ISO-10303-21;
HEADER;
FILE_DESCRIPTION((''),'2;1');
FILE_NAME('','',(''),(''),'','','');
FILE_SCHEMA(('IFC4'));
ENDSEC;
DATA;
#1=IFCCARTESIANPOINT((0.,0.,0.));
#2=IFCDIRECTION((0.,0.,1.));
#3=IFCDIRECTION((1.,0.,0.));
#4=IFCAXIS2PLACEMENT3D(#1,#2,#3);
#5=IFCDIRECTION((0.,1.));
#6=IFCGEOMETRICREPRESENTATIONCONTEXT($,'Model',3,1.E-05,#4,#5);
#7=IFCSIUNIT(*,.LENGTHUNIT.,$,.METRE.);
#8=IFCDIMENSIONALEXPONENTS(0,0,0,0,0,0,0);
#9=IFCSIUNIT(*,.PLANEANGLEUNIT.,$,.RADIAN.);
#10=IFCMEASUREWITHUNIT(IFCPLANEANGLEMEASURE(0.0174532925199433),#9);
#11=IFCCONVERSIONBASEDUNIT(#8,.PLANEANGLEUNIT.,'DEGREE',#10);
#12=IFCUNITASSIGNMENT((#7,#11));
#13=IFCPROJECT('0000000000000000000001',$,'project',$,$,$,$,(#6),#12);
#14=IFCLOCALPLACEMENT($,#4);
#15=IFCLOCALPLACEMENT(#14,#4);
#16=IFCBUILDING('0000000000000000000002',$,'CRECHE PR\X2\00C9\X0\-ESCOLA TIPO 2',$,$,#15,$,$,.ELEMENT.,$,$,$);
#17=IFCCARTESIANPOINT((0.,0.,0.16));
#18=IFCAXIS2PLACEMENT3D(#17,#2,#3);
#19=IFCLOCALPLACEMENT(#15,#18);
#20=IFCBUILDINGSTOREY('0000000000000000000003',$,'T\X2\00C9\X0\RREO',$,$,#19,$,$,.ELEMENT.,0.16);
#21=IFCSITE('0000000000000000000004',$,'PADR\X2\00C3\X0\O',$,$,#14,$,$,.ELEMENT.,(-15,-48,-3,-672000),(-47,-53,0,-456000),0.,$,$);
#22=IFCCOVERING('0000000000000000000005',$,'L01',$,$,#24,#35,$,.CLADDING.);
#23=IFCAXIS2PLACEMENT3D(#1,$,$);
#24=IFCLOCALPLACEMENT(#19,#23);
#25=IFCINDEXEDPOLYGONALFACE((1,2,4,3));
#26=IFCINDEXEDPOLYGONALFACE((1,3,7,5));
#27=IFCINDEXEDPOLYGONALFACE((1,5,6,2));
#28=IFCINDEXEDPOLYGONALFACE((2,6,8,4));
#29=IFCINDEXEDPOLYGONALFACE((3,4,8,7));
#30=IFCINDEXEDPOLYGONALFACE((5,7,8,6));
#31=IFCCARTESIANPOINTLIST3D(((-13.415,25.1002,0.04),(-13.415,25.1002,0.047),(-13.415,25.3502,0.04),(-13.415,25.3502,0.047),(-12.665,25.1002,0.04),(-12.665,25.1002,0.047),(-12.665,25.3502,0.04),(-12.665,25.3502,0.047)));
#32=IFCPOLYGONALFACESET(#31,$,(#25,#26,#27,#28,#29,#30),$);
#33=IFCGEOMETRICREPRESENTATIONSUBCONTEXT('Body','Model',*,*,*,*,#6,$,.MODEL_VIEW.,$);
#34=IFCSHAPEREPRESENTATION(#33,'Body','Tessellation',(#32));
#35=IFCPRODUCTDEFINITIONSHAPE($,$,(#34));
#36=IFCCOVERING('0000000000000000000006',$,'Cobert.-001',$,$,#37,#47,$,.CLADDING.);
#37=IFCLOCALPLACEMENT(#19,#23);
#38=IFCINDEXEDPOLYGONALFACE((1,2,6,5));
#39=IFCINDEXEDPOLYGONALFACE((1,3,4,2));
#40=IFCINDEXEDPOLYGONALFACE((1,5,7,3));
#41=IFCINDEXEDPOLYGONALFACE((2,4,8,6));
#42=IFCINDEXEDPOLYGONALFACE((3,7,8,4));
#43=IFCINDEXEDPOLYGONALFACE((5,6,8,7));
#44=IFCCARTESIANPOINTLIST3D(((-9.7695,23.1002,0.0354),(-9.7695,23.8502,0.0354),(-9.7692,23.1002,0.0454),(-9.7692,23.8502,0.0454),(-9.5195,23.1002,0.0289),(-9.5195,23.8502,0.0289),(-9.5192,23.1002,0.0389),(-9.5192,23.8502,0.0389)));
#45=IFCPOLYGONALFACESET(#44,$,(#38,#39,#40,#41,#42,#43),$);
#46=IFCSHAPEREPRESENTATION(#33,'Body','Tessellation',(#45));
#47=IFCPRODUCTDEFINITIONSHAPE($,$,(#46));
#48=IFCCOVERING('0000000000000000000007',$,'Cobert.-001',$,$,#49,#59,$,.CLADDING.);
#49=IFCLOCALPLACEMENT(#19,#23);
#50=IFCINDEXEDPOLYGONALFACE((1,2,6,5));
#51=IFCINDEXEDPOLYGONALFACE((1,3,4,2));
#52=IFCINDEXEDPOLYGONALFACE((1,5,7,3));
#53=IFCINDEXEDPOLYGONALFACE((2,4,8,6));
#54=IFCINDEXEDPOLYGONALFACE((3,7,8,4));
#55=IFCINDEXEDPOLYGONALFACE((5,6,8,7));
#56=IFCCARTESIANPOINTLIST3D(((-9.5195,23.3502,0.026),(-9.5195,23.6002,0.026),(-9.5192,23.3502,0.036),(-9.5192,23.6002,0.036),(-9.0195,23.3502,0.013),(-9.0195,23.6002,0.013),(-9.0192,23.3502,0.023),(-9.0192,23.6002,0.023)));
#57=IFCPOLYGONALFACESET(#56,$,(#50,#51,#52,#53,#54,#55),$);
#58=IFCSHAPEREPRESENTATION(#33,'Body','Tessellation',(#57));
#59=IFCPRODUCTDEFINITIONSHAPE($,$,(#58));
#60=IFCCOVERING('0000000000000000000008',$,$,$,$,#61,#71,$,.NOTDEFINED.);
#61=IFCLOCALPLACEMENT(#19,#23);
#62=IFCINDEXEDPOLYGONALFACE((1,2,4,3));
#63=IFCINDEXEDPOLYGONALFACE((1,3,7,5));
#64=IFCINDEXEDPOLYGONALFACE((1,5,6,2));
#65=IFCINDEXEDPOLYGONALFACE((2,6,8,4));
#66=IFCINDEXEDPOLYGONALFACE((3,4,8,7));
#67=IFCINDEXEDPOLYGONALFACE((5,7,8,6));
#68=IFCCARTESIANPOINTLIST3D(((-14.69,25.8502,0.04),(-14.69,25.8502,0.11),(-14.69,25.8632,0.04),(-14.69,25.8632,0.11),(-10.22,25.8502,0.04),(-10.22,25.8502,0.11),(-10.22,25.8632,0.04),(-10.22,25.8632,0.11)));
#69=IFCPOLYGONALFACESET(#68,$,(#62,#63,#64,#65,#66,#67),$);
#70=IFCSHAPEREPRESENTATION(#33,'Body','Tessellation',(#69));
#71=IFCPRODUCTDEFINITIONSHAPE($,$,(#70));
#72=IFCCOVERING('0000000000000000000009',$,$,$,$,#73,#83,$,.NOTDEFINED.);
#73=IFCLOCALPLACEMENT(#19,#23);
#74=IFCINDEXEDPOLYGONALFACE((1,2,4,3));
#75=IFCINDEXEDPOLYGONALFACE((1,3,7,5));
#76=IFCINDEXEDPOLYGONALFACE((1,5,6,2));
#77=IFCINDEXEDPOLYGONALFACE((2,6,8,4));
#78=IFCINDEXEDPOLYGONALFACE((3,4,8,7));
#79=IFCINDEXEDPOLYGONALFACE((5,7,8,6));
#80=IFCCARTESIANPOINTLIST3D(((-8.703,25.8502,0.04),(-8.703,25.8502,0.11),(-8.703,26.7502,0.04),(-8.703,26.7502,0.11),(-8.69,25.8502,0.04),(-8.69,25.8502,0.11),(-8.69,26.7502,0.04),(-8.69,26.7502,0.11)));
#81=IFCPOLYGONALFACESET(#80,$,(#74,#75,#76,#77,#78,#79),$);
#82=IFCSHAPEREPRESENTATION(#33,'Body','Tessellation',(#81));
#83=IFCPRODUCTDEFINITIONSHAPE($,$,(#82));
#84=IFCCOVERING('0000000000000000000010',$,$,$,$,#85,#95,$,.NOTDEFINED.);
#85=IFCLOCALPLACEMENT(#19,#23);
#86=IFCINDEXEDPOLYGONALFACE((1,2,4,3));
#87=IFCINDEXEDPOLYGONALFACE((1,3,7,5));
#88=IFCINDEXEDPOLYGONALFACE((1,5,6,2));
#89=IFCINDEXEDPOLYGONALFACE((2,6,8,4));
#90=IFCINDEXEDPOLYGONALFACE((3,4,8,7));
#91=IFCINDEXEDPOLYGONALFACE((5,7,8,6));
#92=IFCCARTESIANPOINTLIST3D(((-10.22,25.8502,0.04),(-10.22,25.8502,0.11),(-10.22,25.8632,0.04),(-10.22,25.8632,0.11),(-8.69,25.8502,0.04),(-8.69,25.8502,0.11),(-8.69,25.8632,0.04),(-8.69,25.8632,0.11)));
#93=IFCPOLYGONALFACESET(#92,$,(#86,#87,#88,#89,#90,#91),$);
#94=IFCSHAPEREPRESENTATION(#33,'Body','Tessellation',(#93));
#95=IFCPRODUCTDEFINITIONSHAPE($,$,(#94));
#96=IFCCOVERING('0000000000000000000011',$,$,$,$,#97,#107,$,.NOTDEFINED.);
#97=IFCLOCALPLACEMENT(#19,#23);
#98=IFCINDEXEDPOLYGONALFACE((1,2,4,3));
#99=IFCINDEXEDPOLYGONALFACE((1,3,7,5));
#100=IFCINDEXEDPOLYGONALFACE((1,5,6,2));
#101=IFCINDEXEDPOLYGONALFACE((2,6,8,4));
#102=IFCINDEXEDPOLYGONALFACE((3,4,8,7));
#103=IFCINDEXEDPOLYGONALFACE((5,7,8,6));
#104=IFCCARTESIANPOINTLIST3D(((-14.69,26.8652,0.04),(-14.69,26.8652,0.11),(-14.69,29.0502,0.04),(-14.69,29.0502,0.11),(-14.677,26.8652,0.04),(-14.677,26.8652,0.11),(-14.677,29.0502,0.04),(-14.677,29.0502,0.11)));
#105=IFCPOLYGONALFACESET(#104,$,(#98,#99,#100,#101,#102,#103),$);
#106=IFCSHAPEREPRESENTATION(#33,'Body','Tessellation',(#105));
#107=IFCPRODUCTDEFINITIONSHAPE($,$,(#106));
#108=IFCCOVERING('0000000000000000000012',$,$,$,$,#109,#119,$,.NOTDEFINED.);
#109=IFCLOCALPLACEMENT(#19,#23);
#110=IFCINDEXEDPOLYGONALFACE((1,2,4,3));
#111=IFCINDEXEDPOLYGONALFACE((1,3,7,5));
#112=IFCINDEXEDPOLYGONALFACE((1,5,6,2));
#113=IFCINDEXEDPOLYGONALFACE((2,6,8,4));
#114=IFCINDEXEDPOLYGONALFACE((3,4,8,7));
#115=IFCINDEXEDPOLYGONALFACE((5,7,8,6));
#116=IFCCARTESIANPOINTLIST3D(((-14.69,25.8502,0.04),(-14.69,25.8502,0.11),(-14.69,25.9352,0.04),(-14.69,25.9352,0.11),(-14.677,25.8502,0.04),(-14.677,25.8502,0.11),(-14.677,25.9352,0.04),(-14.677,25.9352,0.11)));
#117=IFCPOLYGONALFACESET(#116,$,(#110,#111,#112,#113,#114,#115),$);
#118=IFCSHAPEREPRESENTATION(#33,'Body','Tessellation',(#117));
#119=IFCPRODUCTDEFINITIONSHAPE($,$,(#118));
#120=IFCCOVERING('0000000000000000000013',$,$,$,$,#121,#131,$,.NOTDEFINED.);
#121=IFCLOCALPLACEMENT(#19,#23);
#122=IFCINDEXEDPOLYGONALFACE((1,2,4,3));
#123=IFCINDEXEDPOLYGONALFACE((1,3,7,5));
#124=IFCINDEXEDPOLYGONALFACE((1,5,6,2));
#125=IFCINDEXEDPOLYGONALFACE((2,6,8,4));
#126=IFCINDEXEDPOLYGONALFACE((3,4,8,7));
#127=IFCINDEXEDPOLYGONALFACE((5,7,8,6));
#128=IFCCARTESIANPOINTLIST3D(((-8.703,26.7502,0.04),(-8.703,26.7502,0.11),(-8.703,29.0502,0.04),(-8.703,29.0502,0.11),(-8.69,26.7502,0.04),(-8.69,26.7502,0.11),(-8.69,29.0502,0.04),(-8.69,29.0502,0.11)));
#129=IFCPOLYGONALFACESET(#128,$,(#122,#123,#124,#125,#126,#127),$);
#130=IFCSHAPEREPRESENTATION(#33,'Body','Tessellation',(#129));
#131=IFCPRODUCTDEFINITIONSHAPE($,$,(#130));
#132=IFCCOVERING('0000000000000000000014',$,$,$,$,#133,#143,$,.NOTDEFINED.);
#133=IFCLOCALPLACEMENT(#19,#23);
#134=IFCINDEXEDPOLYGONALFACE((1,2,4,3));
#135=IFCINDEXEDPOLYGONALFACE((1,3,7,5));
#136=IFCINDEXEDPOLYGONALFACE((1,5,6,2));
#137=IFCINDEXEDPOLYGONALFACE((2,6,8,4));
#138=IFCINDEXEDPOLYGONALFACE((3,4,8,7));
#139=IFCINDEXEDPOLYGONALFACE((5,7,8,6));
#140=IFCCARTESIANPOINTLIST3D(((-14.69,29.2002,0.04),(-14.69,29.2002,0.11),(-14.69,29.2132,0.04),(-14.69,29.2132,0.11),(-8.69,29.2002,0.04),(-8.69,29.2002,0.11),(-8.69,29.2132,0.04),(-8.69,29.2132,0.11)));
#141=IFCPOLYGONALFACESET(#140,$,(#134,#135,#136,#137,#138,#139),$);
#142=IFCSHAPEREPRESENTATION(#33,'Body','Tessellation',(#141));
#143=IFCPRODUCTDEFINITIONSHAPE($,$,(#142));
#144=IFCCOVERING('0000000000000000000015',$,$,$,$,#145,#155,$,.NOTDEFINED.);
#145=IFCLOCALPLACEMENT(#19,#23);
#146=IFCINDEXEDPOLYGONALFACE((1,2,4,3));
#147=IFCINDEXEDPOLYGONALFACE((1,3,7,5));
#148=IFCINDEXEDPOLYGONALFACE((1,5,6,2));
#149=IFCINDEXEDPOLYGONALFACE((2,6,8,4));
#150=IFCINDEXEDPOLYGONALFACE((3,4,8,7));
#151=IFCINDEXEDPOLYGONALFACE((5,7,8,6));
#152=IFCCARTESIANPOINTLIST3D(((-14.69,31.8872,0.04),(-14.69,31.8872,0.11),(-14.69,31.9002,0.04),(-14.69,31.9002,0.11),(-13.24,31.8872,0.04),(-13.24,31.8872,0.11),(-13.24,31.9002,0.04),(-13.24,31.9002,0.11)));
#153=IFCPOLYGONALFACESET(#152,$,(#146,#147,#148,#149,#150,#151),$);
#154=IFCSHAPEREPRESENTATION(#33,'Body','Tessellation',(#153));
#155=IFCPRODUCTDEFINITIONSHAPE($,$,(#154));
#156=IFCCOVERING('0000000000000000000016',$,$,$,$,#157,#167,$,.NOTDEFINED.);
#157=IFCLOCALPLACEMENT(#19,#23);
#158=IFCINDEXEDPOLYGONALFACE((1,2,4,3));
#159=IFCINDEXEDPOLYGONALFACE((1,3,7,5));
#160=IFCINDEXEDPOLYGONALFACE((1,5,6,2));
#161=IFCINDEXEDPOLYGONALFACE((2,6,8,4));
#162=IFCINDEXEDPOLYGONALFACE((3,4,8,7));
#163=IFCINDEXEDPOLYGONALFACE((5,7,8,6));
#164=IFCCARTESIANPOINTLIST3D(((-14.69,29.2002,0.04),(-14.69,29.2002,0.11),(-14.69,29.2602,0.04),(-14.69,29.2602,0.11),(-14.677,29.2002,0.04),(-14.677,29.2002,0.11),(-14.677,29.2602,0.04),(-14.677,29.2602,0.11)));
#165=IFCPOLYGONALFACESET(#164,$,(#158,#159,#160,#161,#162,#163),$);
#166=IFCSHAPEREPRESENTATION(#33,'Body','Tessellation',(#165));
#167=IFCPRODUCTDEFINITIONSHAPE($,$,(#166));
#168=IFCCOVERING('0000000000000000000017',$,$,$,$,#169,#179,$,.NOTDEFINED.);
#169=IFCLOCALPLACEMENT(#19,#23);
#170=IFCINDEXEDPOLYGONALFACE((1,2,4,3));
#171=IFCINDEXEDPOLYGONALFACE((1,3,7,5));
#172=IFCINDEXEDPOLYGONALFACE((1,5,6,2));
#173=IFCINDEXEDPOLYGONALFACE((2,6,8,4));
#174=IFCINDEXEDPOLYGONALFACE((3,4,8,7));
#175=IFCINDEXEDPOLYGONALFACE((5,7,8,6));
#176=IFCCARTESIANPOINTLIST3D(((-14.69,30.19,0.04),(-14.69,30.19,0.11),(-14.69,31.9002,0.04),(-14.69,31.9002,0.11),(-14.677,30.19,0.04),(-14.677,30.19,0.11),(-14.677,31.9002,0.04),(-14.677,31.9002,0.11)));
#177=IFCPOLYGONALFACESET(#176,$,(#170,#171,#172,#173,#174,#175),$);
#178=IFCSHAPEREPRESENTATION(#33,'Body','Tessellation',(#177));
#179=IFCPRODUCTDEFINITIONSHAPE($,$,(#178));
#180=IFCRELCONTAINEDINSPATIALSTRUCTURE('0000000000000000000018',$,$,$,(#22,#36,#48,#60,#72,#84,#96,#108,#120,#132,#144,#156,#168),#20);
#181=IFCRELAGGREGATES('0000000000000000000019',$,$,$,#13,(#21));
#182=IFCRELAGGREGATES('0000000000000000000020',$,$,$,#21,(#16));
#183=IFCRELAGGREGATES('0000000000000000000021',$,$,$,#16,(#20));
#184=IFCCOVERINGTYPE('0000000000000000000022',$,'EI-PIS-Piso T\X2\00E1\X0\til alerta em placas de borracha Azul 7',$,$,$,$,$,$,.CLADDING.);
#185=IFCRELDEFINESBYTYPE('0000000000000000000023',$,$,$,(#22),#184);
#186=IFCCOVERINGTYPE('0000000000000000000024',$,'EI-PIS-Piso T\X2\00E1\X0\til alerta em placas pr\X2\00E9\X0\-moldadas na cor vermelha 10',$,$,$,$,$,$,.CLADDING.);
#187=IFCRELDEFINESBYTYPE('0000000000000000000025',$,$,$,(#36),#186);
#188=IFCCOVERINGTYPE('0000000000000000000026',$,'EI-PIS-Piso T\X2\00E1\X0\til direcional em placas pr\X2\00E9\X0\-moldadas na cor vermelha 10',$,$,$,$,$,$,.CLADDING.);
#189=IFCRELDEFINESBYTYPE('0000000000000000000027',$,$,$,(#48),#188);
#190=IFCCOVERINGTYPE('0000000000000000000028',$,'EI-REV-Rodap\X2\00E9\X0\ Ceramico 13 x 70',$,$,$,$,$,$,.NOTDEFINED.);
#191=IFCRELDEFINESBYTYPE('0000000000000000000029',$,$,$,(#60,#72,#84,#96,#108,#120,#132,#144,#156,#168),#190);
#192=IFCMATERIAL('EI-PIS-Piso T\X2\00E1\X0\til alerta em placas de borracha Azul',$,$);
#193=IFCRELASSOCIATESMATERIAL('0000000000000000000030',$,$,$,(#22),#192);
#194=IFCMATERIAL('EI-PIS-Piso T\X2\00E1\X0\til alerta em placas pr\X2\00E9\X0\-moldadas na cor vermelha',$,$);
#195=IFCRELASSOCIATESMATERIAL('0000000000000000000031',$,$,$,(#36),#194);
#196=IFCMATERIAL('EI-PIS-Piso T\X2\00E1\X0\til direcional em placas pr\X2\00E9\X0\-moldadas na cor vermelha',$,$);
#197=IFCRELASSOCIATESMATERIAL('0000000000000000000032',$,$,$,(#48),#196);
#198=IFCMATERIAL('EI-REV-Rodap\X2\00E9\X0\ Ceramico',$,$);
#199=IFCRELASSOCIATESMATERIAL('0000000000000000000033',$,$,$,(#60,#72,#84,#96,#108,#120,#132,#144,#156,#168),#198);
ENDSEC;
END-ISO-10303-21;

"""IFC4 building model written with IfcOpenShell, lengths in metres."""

from ifc_helpers import new_model, entity, si_unit, converted_unit, direction, frame, frame_2d, origin_with_axes, place, context, subcontext, project, spatial, line, indexed_curve, rectangle, outline, extrude, material, type_object, element, save


model = new_model("IFC4")

# Units and contexts
model_context = context("Model", 3, precision=1e-05, world=origin_with_axes(), true_north=direction((0.0, 1.0)))
body_context = subcontext(model_context, "Body", "Model", "MODEL_VIEW")
ifc_project = project(units=[si_unit("LENGTHUNIT", "METRE"), converted_unit("PLANEANGLEUNIT", "DEGREE", entity("IfcPlaneAngleMeasure", 0.0174532925199433), si_unit("PLANEANGLEUNIT", "RADIAN"), dimensions=[0, 0, 0, 0, 0, 0, 0])], contexts=[model_context])

# Site, building, storey
site_placement = place(None, origin_with_axes())
site = spatial("IfcSite", under=ifc_project, at=site_placement, Name="PADRÃO", CompositionType="ELEMENT", RefLatitude=(-15, -48, -3, -672000), RefLongitude=(-47, -53, 0, -456000), RefElevation=0.0)
building_placement = place(site_placement, origin_with_axes())
building = spatial("IfcBuilding", under=site, at=building_placement, Name="CRECHE PRÉ-ESCOLA TIPO 2", CompositionType="ELEMENT")
storey_placement = place(building_placement, frame((0.0, 0.0, 0.16), z_axis=(0.0, 0.0, 1.0), x_axis=(1.0, 0.0, 0.0)))
storey = spatial("IfcBuildingStorey", under=building, at=storey_placement, Name="TÉRREO", CompositionType="ELEMENT", Elevation=0.16)

# Coverings
ifc_material_1 = material(Name="EI-PIS-Piso Tátil alerta em placas de borracha Azul")
covering_type_1 = type_object("IfcCoveringType", Name="EI-PIS-Piso Tátil alerta em placas de borracha Azul 7", PredefinedType="CLADDING")
covering_1_placement = place(storey_placement, frame((-13.415, 25.1002, 0.04), z_axis=(0.0, 0.0, 1.0), x_axis=(1.0, 0.0, 0.0)))
element("IfcCovering", 1, at=covering_1_placement, inside=storey, type_object=covering_type_1, material=ifc_material_1, Name="L01", PredefinedType="CLADDING", context=body_context, shape_type="SweptSolid", body=[
    extrude(outline(indexed_curve([(0.0, 0.0), (0.75, 0.0), (0.75, 0.25), (0.0, 0.25)], segments=[line(1, 2, 3, 4, 1)])), origin_with_axes(), (0.0, 0.0, 1.0), 0.007),
])
ifc_material_2 = material(Name="EI-PIS-Piso Tátil alerta em placas pré-moldadas na cor vermelha")
covering_type_2 = type_object("IfcCoveringType", Name="EI-PIS-Piso Tátil alerta em placas pré-moldadas na cor vermelha 10", PredefinedType="CLADDING")
covering_2_placement = place(storey_placement, frame((-9.5192, 23.1002, 0.0289), z_axis=(0.0, 0.0, 1.0), x_axis=(0.0, 1.0, 0.0)))
element("IfcCovering", 2, at=covering_2_placement, inside=storey, type_object=covering_type_2, material=ifc_material_2, Name="Cobert.-001", PredefinedType="CLADDING", context=body_context, shape_type="SweptSolid", body=[
    extrude(outline(indexed_curve([(0.0, 0.0003), (0.75, 0.0003), (0.75, 0.2503), (0.0, 0.2503)], segments=[line(1, 2, 3, 4, 1)])), frame((0.0, 0.0, 0.0), z_axis=(0.0, -0.025991, 0.999662), x_axis=(1.0, 0.0, 0.0)), (0.0, 0.0, 1.0), 0.01),
])
ifc_material_3 = material(Name="EI-PIS-Piso Tátil direcional em placas pré-moldadas na cor vermelha")
covering_type_3 = type_object("IfcCoveringType", Name="EI-PIS-Piso Tátil direcional em placas pré-moldadas na cor vermelha 10", PredefinedType="CLADDING")
covering_3_placement = place(storey_placement, frame((-9.0192, 23.3502, 0.013), z_axis=(0.0, 0.0, 1.0), x_axis=(0.0, 1.0, 0.0)))
element("IfcCovering", 3, at=covering_3_placement, inside=storey, type_object=covering_type_3, material=ifc_material_3, Name="Cobert.-001", PredefinedType="CLADDING", context=body_context, shape_type="SweptSolid", body=[
    extrude(outline(indexed_curve([(0.25, 0.0003), (0.25, 0.5004), (0.0, 0.5004), (0.0, 0.0003)], segments=[line(1, 2, 3, 4, 1)])), frame((0.0, 0.0, 0.0), z_axis=(0.0, -0.025991, 0.999662), x_axis=(1.0, 0.0, 0.0)), (0.0, 0.0, 1.0), 0.01),
])
ifc_material_4 = material(Name="EI-REV-Rodapé Ceramico")
covering_type_4 = type_object("IfcCoveringType", Name="EI-REV-Rodapé Ceramico 13 x 70", PredefinedType="NOTDEFINED")
covering_4_placement = place(storey_placement, frame((-14.69, 25.8502, 0.04), z_axis=(0.0, 0.0, 1.0), x_axis=(0.0, -1.0, 0.0)))
element("IfcCovering", 4, at=covering_4_placement, inside=storey, type_object=covering_type_4, material=ifc_material_4, PredefinedType="NOTDEFINED", context=body_context, shape_type="SweptSolid", body=[
    extrude(rectangle(XDim=0.07, YDim=0.013, at=frame_2d((0.035, -0.0065), x_axis=(1.0, 0.0))), frame((0.0, 0.0, 0.0), z_axis=(0.0, 1.0, 0.0), x_axis=(0.0, 0.0, 1.0)), (0.0, 0.0, 1.0), 4.47),
])
covering_5_placement = place(storey_placement, frame((-8.69, 25.8502, 0.04), z_axis=(0.0, 0.0, 1.0), x_axis=(1.0, 0.0, 0.0)))
element("IfcCovering", 5, at=covering_5_placement, inside=storey, type_object=covering_type_4, material=ifc_material_4, PredefinedType="NOTDEFINED", context=body_context, shape_type="SweptSolid", body=[
    extrude(rectangle(XDim=0.07, YDim=0.013, at=frame_2d((0.035, -0.0065), x_axis=(1.0, 0.0))), frame((0.0, 0.0, 0.0), z_axis=(0.0, 1.0, 0.0), x_axis=(0.0, 0.0, 1.0)), (0.0, 0.0, 1.0), 0.9),
])
covering_6_placement = place(storey_placement, frame((-10.22, 25.8502, 0.04), z_axis=(0.0, 0.0, 1.0), x_axis=(0.0, -1.0, 0.0)))
element("IfcCovering", 6, at=covering_6_placement, inside=storey, type_object=covering_type_4, material=ifc_material_4, PredefinedType="NOTDEFINED", context=body_context, shape_type="SweptSolid", body=[
    extrude(rectangle(XDim=0.07, YDim=0.013, at=frame_2d((0.035, -0.0065), x_axis=(1.0, 0.0))), frame((0.0, 0.0, 0.0), z_axis=(0.0, 1.0, 0.0), x_axis=(0.0, 0.0, 1.0)), (0.0, 0.0, 1.0), 1.53),
])
covering_7_placement = place(storey_placement, frame((-14.69, 29.0502, 0.04), z_axis=(0.0, 0.0, 1.0), x_axis=(-1.0, 0.0, 0.0)))
element("IfcCovering", 7, at=covering_7_placement, inside=storey, type_object=covering_type_4, material=ifc_material_4, PredefinedType="NOTDEFINED", context=body_context, shape_type="SweptSolid", body=[
    extrude(rectangle(XDim=0.07, YDim=0.013, at=frame_2d((0.035, -0.0065), x_axis=(1.0, 0.0))), frame((0.0, 0.0, 0.0), z_axis=(0.0, 1.0, 0.0), x_axis=(0.0, 0.0, 1.0)), (0.0, 0.0, 1.0), 2.185),
])
covering_8_placement = place(storey_placement, frame((-14.69, 25.9352, 0.04), z_axis=(0.0, 0.0, 1.0), x_axis=(-1.0, 0.0, 0.0)))
element("IfcCovering", 8, at=covering_8_placement, inside=storey, type_object=covering_type_4, material=ifc_material_4, PredefinedType="NOTDEFINED", context=body_context, shape_type="SweptSolid", body=[
    extrude(rectangle(XDim=0.07, YDim=0.013, at=frame_2d((0.035, -0.0065), x_axis=(1.0, 0.0))), frame((0.0, 0.0, 0.0), z_axis=(0.0, 1.0, 0.0), x_axis=(0.0, 0.0, 1.0)), (0.0, 0.0, 1.0), 0.085),
])
covering_9_placement = place(storey_placement, frame((-8.69, 26.7502, 0.04), z_axis=(0.0, 0.0, 1.0), x_axis=(1.0, 0.0, 0.0)))
element("IfcCovering", 9, at=covering_9_placement, inside=storey, type_object=covering_type_4, material=ifc_material_4, PredefinedType="NOTDEFINED", context=body_context, shape_type="SweptSolid", body=[
    extrude(rectangle(XDim=0.07, YDim=0.013, at=frame_2d((0.035, -0.0065), x_axis=(1.0, 0.0))), frame((0.0, 0.0, 0.0), z_axis=(0.0, 1.0, 0.0), x_axis=(0.0, 0.0, 1.0)), (0.0, 0.0, 1.0), 2.3),
])
covering_10_placement = place(storey_placement, frame((-14.69, 29.2002, 0.04), z_axis=(0.0, 0.0, 1.0), x_axis=(0.0, -1.0, 0.0)))
element("IfcCovering", 10, at=covering_10_placement, inside=storey, type_object=covering_type_4, material=ifc_material_4, PredefinedType="NOTDEFINED", context=body_context, shape_type="SweptSolid", body=[
    extrude(rectangle(XDim=0.07, YDim=0.013, at=frame_2d((0.035, -0.0065), x_axis=(1.0, 0.0))), frame((0.0, 0.0, 0.0), z_axis=(0.0, 1.0, 0.0), x_axis=(0.0, 0.0, 1.0)), (0.0, 0.0, 1.0), 6.0),
])
covering_11_placement = place(storey_placement, frame((-13.24, 31.9002, 0.04), z_axis=(0.0, 0.0, 1.0), x_axis=(0.0, 1.0, 0.0)))
element("IfcCovering", 11, at=covering_11_placement, inside=storey, type_object=covering_type_4, material=ifc_material_4, PredefinedType="NOTDEFINED", context=body_context, shape_type="SweptSolid", body=[
    extrude(rectangle(XDim=0.07, YDim=0.013, at=frame_2d((0.035, -0.0065), x_axis=(1.0, 0.0))), frame((0.0, 0.0, 0.0), z_axis=(0.0, 1.0, 0.0), x_axis=(0.0, 0.0, 1.0)), (0.0, 0.0, 1.0), 1.45),
])
covering_12_placement = place(storey_placement, frame((-14.69, 29.2602, 0.04), z_axis=(0.0, 0.0, 1.0), x_axis=(-1.0, 0.0, 0.0)))
element("IfcCovering", 12, at=covering_12_placement, inside=storey, type_object=covering_type_4, material=ifc_material_4, PredefinedType="NOTDEFINED", context=body_context, shape_type="SweptSolid", body=[
    extrude(rectangle(XDim=0.07, YDim=0.013, at=frame_2d((0.035, -0.0065), x_axis=(1.0, 0.0))), frame((0.0, 0.0, 0.0), z_axis=(0.0, 1.0, 0.0), x_axis=(0.0, 0.0, 1.0)), (0.0, 0.0, 1.0), 0.06),
])
covering_13_placement = place(storey_placement, frame((-14.69, 31.9002, 0.04), z_axis=(0.0, 0.0, 1.0), x_axis=(-1.0, 0.0, 0.0)))
element("IfcCovering", 13, at=covering_13_placement, inside=storey, type_object=covering_type_4, material=ifc_material_4, PredefinedType="NOTDEFINED", context=body_context, shape_type="SweptSolid", body=[
    extrude(rectangle(XDim=0.07, YDim=0.013, at=frame_2d((0.035, -0.0065), x_axis=(1.0, 0.0))), frame((0.0, 0.0, 0.0), z_axis=(0.0, 1.0, 0.0), x_axis=(0.0, 0.0, 1.0)), (0.0, 0.0, 1.0), 1.7101),
])

save(model, "model.ifc")
